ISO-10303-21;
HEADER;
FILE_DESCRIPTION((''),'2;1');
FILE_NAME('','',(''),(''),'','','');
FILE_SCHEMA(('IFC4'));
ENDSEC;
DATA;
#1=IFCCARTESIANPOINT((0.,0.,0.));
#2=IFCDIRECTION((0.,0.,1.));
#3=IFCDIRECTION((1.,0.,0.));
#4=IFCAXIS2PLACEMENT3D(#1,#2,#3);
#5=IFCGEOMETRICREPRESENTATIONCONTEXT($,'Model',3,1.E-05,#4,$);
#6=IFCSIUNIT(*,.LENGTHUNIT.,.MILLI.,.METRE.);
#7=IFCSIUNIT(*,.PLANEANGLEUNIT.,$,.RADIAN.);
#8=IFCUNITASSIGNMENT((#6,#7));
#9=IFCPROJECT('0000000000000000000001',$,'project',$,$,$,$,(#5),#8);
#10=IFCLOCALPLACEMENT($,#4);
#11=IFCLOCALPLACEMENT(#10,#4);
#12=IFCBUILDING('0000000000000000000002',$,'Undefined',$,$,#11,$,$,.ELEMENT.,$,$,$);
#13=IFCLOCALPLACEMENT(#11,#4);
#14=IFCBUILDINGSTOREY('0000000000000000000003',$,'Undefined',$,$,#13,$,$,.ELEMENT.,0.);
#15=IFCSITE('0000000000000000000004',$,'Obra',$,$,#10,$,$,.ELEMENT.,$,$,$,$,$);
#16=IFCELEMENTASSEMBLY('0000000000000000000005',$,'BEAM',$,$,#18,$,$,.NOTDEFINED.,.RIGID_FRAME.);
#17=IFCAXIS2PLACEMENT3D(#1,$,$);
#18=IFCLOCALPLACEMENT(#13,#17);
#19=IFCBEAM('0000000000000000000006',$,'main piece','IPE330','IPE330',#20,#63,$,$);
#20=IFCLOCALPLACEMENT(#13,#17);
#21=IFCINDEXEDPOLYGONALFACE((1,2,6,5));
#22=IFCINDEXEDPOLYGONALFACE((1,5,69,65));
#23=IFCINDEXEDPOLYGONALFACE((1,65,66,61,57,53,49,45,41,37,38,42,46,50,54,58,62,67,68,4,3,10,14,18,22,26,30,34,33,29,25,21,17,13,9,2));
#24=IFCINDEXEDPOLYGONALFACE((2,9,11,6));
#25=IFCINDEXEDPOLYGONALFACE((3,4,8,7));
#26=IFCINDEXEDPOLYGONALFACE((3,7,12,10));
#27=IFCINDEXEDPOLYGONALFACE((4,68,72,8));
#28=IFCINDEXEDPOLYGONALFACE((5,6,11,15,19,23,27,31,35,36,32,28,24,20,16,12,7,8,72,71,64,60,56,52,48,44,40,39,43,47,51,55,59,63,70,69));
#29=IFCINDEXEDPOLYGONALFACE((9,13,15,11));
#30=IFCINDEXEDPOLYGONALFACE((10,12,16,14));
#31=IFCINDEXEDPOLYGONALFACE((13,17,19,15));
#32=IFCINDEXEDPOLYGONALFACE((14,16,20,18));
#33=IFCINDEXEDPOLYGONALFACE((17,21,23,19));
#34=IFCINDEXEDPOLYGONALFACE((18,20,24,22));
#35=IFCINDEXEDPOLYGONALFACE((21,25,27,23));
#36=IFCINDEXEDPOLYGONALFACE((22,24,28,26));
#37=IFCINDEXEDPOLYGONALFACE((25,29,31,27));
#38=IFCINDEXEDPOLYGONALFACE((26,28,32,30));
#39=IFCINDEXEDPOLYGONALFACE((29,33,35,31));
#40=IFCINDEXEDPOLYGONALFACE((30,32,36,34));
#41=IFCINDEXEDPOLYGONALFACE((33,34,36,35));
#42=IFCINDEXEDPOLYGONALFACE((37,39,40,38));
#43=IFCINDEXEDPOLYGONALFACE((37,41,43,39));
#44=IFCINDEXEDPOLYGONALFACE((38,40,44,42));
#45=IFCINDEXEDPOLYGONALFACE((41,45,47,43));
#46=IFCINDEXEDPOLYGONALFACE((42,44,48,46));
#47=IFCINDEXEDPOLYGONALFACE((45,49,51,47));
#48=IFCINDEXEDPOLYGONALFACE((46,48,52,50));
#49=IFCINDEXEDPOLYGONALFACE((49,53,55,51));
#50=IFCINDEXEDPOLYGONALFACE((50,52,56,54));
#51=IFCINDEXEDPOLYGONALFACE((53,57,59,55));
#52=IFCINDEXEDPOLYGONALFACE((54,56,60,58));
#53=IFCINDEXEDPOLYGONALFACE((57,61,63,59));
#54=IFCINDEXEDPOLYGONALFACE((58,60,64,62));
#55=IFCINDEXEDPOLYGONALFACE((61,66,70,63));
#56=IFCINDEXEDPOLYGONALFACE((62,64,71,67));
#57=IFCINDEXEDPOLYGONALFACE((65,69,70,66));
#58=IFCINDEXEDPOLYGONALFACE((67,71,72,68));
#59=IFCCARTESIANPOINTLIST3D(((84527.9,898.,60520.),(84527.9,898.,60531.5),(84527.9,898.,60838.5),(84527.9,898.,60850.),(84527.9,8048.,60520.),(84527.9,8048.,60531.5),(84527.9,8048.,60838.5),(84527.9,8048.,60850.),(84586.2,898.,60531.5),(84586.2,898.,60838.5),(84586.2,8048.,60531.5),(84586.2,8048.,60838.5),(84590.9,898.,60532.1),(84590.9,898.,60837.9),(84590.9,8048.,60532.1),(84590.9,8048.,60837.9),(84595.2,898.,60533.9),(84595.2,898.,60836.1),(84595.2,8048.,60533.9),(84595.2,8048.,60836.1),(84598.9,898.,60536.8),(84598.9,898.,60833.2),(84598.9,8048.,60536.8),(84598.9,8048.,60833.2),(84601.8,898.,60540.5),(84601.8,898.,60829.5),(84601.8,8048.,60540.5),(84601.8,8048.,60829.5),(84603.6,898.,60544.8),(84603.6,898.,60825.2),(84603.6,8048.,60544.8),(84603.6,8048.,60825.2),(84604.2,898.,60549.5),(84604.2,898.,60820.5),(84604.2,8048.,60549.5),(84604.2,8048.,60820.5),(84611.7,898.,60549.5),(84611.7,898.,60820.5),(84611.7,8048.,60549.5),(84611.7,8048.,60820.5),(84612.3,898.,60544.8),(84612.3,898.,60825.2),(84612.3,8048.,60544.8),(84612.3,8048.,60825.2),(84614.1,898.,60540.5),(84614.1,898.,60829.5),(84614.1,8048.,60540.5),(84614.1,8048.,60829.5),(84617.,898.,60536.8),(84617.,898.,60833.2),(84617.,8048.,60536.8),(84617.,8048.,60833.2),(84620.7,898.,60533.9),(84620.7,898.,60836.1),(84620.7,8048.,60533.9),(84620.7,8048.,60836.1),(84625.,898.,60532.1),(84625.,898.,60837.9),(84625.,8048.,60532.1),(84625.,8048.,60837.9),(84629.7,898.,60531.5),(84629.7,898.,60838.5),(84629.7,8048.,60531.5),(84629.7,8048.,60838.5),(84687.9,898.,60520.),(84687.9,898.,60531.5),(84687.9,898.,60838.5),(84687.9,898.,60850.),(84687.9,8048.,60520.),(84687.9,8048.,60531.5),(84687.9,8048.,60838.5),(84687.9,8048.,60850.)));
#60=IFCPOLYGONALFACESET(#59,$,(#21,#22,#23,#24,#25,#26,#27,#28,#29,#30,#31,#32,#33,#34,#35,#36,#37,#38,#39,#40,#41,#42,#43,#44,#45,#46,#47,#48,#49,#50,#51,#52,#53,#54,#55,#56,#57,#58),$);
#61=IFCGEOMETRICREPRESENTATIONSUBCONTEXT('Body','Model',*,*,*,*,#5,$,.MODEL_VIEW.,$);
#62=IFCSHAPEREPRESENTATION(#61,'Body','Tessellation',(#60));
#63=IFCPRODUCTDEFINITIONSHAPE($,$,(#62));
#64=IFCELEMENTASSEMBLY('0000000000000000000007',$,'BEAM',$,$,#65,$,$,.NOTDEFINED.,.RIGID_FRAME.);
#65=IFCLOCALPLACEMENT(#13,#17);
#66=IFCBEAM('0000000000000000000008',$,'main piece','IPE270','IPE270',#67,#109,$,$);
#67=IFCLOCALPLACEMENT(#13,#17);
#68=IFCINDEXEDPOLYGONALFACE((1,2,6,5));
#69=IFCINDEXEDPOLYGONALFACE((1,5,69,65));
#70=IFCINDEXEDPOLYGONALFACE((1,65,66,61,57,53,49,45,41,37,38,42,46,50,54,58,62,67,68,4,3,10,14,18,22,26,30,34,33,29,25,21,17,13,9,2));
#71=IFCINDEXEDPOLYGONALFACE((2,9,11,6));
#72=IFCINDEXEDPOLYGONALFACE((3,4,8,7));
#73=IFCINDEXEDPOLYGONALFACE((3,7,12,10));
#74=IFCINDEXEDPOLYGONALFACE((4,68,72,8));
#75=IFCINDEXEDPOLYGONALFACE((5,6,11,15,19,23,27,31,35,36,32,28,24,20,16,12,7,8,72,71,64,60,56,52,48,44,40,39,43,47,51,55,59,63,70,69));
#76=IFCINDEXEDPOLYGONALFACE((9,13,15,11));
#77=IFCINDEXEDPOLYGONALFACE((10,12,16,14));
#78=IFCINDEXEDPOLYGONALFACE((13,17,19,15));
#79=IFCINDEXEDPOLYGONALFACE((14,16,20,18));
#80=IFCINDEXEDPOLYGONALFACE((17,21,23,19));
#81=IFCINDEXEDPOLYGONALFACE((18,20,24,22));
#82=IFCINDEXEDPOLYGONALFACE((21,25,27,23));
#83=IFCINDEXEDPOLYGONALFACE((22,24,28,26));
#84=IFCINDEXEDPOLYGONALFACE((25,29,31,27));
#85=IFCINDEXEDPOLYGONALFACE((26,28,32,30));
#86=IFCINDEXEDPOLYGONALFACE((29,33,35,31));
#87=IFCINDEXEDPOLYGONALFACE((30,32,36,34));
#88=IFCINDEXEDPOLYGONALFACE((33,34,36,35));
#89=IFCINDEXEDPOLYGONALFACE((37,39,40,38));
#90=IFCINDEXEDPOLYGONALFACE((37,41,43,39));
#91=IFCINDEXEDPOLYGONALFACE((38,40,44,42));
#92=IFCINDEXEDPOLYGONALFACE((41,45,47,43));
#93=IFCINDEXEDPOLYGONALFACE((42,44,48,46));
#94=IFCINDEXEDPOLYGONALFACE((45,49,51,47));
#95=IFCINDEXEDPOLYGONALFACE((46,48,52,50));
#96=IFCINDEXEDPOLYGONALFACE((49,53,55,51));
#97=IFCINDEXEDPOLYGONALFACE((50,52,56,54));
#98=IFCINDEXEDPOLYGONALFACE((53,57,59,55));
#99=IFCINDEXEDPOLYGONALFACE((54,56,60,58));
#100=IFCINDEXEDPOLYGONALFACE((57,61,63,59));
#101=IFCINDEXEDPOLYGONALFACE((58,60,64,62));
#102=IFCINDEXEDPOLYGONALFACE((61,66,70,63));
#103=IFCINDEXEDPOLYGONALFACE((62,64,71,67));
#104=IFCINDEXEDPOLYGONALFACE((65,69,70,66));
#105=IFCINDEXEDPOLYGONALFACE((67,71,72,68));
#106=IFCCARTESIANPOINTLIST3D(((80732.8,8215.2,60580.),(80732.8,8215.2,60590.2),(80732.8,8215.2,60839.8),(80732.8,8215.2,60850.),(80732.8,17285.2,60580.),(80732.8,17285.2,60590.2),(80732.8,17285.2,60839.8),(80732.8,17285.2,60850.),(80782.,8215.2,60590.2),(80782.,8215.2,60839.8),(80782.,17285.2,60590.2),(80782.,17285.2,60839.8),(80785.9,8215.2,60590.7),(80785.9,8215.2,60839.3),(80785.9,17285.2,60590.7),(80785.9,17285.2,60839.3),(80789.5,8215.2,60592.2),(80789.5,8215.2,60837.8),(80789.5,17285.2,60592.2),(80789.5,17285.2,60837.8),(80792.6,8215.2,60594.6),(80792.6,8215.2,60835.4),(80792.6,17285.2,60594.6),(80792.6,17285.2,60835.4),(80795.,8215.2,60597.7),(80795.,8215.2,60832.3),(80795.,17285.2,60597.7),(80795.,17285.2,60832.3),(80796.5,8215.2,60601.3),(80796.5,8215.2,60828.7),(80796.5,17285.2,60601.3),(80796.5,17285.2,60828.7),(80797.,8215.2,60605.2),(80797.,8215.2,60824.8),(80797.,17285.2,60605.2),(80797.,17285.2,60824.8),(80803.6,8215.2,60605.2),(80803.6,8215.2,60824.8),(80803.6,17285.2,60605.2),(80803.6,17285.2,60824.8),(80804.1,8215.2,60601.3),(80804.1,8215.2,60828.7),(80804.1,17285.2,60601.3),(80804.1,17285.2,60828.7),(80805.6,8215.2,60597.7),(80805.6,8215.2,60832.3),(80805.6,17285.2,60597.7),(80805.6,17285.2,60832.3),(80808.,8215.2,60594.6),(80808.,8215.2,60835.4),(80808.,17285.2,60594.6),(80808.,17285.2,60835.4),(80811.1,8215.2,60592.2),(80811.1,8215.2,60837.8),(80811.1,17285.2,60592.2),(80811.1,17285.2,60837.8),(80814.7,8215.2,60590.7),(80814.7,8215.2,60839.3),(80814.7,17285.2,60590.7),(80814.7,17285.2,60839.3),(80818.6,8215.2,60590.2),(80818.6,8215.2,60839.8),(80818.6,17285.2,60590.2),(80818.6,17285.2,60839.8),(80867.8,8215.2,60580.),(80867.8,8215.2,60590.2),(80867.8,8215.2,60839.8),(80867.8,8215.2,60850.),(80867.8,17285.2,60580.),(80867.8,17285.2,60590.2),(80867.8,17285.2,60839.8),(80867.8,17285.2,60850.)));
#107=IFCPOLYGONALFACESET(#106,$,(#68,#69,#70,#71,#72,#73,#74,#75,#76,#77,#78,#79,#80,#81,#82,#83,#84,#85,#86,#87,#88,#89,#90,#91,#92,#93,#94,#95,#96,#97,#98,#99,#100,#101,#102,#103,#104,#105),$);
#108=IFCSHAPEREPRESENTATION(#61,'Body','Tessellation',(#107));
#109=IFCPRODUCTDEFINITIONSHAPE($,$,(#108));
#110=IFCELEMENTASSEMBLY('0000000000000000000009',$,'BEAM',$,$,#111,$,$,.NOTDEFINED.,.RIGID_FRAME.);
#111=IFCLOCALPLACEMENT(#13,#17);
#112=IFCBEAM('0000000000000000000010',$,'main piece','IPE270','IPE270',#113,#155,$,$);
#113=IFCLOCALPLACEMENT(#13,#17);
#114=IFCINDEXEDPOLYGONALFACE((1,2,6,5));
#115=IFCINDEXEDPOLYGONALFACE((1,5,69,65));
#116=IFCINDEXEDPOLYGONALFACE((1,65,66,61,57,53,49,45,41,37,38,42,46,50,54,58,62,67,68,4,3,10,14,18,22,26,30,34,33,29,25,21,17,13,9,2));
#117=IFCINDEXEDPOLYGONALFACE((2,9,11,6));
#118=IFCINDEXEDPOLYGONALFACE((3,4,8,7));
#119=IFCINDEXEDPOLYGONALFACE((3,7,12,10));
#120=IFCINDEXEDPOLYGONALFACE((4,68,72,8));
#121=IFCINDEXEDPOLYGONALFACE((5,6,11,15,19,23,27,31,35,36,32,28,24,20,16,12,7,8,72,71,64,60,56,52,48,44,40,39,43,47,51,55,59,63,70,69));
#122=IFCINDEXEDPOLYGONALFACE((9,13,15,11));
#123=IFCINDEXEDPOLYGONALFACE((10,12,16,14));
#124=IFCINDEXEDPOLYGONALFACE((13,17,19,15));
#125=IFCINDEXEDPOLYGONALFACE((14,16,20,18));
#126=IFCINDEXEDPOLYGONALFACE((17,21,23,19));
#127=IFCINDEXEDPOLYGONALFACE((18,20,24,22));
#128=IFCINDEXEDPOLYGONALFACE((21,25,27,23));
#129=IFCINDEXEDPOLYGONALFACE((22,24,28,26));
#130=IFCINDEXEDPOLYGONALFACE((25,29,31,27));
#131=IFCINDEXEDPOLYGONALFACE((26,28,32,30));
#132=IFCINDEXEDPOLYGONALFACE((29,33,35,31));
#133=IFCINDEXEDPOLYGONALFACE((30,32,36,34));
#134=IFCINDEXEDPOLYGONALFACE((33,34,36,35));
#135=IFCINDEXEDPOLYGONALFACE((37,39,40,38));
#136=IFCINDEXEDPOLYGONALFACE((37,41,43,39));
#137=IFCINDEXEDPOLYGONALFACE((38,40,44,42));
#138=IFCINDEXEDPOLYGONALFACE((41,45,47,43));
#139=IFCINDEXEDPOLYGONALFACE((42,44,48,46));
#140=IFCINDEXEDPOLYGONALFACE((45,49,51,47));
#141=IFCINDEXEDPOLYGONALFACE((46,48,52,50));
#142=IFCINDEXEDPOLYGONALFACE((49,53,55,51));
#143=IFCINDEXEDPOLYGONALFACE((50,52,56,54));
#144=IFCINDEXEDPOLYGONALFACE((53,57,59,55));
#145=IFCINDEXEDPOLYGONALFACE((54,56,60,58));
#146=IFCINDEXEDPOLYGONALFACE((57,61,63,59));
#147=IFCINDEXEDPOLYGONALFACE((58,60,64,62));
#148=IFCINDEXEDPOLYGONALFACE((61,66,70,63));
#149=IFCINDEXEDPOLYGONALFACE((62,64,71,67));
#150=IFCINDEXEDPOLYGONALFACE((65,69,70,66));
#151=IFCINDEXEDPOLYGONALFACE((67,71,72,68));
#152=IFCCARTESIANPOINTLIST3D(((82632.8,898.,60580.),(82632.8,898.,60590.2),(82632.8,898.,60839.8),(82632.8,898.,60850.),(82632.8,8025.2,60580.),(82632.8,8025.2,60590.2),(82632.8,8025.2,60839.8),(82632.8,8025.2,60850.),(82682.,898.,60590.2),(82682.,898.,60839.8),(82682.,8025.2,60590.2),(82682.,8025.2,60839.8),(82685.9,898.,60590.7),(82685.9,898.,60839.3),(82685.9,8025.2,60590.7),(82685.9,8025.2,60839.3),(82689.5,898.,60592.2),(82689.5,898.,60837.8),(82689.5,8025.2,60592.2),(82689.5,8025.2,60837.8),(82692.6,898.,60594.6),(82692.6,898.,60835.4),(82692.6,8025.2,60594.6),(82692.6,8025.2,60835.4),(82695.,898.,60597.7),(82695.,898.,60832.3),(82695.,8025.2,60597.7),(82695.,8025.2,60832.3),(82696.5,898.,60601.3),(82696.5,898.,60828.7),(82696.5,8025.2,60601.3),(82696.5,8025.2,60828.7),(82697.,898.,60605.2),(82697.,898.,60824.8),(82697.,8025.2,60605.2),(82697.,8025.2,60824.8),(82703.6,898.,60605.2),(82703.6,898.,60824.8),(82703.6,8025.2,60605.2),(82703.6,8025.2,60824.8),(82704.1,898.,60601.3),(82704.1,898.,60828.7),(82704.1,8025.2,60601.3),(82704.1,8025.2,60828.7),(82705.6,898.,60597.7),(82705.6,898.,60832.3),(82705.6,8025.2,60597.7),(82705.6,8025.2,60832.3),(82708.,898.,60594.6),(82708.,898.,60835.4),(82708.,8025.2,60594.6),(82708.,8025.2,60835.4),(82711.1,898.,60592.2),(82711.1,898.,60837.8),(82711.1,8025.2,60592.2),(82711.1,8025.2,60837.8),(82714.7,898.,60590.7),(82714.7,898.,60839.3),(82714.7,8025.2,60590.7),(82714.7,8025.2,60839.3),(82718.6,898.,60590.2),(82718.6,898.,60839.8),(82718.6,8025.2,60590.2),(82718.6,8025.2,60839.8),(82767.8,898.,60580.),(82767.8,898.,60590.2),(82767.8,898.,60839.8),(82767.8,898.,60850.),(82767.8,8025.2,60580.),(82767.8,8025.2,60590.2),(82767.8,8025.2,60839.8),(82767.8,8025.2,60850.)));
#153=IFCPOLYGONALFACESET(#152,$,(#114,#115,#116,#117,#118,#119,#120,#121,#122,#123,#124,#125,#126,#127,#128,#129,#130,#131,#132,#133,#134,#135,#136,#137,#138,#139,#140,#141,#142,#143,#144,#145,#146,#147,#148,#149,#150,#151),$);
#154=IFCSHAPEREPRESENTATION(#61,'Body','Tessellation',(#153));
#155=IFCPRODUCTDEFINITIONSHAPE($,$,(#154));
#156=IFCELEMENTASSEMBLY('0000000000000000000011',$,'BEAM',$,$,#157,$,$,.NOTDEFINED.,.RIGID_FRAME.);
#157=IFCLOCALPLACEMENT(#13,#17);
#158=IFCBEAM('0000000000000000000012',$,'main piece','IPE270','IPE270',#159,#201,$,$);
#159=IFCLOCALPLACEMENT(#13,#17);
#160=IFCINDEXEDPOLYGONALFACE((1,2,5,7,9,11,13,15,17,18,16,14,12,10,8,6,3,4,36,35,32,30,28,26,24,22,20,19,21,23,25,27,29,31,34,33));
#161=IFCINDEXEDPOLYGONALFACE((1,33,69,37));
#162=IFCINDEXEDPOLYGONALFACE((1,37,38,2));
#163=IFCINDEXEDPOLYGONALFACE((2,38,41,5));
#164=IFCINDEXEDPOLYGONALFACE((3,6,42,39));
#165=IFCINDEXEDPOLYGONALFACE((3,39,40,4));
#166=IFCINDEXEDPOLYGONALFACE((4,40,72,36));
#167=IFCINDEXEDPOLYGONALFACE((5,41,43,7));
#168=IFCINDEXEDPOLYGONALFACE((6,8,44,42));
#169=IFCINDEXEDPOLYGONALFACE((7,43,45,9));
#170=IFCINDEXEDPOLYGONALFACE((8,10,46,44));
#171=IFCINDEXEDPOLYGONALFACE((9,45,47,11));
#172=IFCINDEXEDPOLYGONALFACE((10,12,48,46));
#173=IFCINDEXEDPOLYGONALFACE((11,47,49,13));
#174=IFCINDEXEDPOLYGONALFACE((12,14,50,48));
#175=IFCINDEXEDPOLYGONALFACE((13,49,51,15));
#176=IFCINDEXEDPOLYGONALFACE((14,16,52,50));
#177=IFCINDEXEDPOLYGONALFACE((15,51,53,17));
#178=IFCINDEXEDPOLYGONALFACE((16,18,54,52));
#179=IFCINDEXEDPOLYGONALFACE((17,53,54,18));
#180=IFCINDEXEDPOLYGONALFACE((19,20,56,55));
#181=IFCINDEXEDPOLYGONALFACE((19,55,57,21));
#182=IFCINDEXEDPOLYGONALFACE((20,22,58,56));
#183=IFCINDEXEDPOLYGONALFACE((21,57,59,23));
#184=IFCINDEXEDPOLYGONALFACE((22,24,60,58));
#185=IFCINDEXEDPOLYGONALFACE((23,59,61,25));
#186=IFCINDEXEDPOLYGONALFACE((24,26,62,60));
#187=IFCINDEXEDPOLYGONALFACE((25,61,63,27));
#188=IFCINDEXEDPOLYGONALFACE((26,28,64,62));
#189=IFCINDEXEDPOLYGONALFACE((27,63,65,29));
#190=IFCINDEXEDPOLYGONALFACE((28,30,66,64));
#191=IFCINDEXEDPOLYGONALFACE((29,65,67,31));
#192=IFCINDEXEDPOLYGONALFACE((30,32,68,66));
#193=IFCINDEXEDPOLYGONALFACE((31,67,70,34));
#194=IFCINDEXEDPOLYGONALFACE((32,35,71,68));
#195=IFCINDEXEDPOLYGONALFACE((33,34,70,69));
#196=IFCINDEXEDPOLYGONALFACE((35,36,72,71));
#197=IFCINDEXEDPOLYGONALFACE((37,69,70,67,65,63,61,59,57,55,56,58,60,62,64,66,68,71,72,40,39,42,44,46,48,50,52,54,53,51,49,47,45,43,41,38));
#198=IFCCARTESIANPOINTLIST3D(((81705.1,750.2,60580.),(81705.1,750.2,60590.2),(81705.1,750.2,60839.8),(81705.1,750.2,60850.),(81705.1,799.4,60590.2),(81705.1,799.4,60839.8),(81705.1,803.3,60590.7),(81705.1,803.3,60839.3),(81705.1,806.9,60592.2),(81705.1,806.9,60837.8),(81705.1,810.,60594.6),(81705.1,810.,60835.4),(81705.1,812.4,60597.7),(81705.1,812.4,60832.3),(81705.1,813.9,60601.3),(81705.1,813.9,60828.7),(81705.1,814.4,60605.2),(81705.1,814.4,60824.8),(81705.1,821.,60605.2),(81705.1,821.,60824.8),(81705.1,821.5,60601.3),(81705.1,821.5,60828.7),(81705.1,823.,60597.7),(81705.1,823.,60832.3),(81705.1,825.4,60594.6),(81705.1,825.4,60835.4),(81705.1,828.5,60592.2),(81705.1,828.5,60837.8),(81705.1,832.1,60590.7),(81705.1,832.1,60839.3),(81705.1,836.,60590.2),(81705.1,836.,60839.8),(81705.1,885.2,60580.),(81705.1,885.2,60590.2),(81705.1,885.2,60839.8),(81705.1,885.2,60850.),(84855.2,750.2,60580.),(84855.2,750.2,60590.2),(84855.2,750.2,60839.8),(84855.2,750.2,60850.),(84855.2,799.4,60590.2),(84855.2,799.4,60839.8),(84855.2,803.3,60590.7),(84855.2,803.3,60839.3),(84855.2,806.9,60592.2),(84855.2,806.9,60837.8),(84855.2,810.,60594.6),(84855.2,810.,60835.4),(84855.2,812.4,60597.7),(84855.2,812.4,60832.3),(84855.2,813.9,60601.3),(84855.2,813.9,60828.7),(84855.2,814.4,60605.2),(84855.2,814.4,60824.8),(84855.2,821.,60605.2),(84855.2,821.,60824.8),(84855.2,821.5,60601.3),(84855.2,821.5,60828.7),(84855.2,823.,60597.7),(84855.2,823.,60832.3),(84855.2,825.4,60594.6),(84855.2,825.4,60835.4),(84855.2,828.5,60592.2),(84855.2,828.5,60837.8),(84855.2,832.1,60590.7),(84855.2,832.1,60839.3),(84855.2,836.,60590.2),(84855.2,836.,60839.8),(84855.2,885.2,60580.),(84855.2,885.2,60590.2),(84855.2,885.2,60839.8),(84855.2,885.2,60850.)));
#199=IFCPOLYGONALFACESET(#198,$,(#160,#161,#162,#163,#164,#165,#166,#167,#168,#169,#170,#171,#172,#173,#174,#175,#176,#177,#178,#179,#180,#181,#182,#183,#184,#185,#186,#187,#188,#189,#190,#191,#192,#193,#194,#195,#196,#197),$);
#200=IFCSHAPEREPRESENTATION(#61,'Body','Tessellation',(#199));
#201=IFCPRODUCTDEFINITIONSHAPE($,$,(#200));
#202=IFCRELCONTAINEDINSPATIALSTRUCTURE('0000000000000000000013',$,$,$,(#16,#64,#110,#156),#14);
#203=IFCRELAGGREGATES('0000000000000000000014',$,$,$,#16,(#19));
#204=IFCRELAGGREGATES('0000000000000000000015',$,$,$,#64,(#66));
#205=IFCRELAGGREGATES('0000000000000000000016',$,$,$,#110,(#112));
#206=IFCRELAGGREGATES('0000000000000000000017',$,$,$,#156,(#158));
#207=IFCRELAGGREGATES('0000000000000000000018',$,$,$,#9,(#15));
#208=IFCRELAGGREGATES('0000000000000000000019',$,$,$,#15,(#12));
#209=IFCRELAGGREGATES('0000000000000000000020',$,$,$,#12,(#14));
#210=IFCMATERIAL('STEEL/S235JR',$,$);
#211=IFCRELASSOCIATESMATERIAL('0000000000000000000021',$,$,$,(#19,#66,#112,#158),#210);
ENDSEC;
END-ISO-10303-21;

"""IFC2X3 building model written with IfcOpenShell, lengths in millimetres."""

from ifc_helpers import new_model, si_unit, frame, origin_with_axes, origin_2d_with_axis, place, context, subcontext, project, spatial, i_section, extrude, material, element, aggregate, save


model = new_model("IFC2X3")

# Units and contexts
model_context = context("Model", 3, precision=1e-05, world=origin_with_axes())
body_context = subcontext(model_context, "Body", "Model", "MODEL_VIEW")
ifc_project = project(units=[si_unit("LENGTHUNIT", "METRE", prefix="MILLI"), si_unit("PLANEANGLEUNIT", "RADIAN")], contexts=[model_context])

# Site, building, storey
site_placement = place(None, origin_with_axes())
site = spatial("IfcSite", under=ifc_project, at=site_placement, Name="Obra", CompositionType="ELEMENT")
building_placement = place(site_placement, origin_with_axes())
building = spatial("IfcBuilding", under=site, at=building_placement, Name="Undefined", CompositionType="ELEMENT")
storey_placement = place(building_placement, origin_with_axes())
storey = spatial("IfcBuildingStorey", under=building, at=storey_placement, Name="Undefined", CompositionType="ELEMENT", Elevation=0.0)

# Shared definitions
ifc_material_1 = material(Name="STEEL/S235JR")

# Element assemblies, beams
assembly_1_placement = place(storey_placement, origin_with_axes())
assembly_1 = element("IfcElementAssembly", 1, at=assembly_1_placement, inside=storey, Name="BEAM", AssemblyPlace="NOTDEFINED", PredefinedType="RIGID_FRAME")
beam_1_placement = place(assembly_1_placement, frame((84607.9, 898.0, 60685.0), z_axis=(0.0, 0.0, 1.0), x_axis=(0.0, 1.0, 0.0)))
beam_1 = element("IfcBeam", 2, at=beam_1_placement, material=ifc_material_1, Name="main piece", Description="IPE330", ObjectType="IPE330", context=body_context, shape_type="SweptSolid", body=[
    extrude(i_section(OverallWidth=160.0, OverallDepth=330.0, WebThickness=7.5, FlangeThickness=11.5, FilletRadius=18.0, at=origin_2d_with_axis()), frame((7150.0, 0.0, 0.0), z_axis=(-1.0, 0.0, 0.0), x_axis=(0.0, -1.0, 0.0)), (0.0, 0.0, 1.0), 7150.0),
])
aggregate(assembly_1, [beam_1])
assembly_2_placement = place(storey_placement, origin_with_axes())
assembly_2 = element("IfcElementAssembly", 3, at=assembly_2_placement, inside=storey, Name="BEAM", AssemblyPlace="NOTDEFINED", PredefinedType="RIGID_FRAME")
beam_2_placement = place(assembly_2_placement, frame((80800.3, 8215.2, 60715.0), z_axis=(0.0, 0.0, 1.0), x_axis=(0.0, 1.0, 0.0)))
beam_2 = element("IfcBeam", 4, at=beam_2_placement, material=ifc_material_1, Name="main piece", Description="IPE270", ObjectType="IPE270", context=body_context, shape_type="SweptSolid", body=[
    extrude(i_section(OverallWidth=135.0, OverallDepth=270.0, WebThickness=6.6, FlangeThickness=10.2, FilletRadius=15.0, at=origin_2d_with_axis()), frame((9070.0, 0.0, 0.0), z_axis=(-1.0, 0.0, 0.0), x_axis=(0.0, -1.0, 0.0)), (0.0, 0.0, 1.0), 9070.0),
])
aggregate(assembly_2, [beam_2])
assembly_3_placement = place(storey_placement, origin_with_axes())
assembly_3 = element("IfcElementAssembly", 5, at=assembly_3_placement, inside=storey, Name="BEAM", AssemblyPlace="NOTDEFINED", PredefinedType="RIGID_FRAME")
beam_3_placement = place(assembly_3_placement, frame((82700.3, 898.0, 60715.0), z_axis=(0.0, 0.0, 1.0), x_axis=(0.0, 1.0, 0.0)))
beam_3 = element("IfcBeam", 6, at=beam_3_placement, material=ifc_material_1, Name="main piece", Description="IPE270", ObjectType="IPE270", context=body_context, shape_type="SweptSolid", body=[
    extrude(i_section(OverallWidth=135.0, OverallDepth=270.0, WebThickness=6.6, FlangeThickness=10.2, FilletRadius=15.0, at=origin_2d_with_axis()), frame((7127.2, 0.0, 0.0), z_axis=(-1.0, 0.0, 0.0), x_axis=(0.0, -1.0, 0.0)), (0.0, 0.0, 1.0), 7127.2),
])
aggregate(assembly_3, [beam_3])
assembly_4_placement = place(storey_placement, origin_with_axes())
assembly_4 = element("IfcElementAssembly", 7, at=assembly_4_placement, inside=storey, Name="BEAM", AssemblyPlace="NOTDEFINED", PredefinedType="RIGID_FRAME")
beam_4_placement = place(assembly_4_placement, frame((81705.1, 817.7, 60715.0), z_axis=(0.0, 0.0, 1.0), x_axis=(1.0, 0.0, 0.0)))
beam_4 = element("IfcBeam", 8, at=beam_4_placement, material=ifc_material_1, Name="main piece", Description="IPE270", ObjectType="IPE270", context=body_context, shape_type="SweptSolid", body=[
    extrude(i_section(OverallWidth=135.0, OverallDepth=270.0, WebThickness=6.6, FlangeThickness=10.2, FilletRadius=15.0, at=origin_2d_with_axis()), frame((3150.0, 0.0, 0.0), z_axis=(-1.0, 0.0, 0.0), x_axis=(0.0, -1.0, 0.0)), (0.0, 0.0, 1.0), 3150.0),
])
aggregate(assembly_4, [beam_4])

save(model, "model.ifc")
